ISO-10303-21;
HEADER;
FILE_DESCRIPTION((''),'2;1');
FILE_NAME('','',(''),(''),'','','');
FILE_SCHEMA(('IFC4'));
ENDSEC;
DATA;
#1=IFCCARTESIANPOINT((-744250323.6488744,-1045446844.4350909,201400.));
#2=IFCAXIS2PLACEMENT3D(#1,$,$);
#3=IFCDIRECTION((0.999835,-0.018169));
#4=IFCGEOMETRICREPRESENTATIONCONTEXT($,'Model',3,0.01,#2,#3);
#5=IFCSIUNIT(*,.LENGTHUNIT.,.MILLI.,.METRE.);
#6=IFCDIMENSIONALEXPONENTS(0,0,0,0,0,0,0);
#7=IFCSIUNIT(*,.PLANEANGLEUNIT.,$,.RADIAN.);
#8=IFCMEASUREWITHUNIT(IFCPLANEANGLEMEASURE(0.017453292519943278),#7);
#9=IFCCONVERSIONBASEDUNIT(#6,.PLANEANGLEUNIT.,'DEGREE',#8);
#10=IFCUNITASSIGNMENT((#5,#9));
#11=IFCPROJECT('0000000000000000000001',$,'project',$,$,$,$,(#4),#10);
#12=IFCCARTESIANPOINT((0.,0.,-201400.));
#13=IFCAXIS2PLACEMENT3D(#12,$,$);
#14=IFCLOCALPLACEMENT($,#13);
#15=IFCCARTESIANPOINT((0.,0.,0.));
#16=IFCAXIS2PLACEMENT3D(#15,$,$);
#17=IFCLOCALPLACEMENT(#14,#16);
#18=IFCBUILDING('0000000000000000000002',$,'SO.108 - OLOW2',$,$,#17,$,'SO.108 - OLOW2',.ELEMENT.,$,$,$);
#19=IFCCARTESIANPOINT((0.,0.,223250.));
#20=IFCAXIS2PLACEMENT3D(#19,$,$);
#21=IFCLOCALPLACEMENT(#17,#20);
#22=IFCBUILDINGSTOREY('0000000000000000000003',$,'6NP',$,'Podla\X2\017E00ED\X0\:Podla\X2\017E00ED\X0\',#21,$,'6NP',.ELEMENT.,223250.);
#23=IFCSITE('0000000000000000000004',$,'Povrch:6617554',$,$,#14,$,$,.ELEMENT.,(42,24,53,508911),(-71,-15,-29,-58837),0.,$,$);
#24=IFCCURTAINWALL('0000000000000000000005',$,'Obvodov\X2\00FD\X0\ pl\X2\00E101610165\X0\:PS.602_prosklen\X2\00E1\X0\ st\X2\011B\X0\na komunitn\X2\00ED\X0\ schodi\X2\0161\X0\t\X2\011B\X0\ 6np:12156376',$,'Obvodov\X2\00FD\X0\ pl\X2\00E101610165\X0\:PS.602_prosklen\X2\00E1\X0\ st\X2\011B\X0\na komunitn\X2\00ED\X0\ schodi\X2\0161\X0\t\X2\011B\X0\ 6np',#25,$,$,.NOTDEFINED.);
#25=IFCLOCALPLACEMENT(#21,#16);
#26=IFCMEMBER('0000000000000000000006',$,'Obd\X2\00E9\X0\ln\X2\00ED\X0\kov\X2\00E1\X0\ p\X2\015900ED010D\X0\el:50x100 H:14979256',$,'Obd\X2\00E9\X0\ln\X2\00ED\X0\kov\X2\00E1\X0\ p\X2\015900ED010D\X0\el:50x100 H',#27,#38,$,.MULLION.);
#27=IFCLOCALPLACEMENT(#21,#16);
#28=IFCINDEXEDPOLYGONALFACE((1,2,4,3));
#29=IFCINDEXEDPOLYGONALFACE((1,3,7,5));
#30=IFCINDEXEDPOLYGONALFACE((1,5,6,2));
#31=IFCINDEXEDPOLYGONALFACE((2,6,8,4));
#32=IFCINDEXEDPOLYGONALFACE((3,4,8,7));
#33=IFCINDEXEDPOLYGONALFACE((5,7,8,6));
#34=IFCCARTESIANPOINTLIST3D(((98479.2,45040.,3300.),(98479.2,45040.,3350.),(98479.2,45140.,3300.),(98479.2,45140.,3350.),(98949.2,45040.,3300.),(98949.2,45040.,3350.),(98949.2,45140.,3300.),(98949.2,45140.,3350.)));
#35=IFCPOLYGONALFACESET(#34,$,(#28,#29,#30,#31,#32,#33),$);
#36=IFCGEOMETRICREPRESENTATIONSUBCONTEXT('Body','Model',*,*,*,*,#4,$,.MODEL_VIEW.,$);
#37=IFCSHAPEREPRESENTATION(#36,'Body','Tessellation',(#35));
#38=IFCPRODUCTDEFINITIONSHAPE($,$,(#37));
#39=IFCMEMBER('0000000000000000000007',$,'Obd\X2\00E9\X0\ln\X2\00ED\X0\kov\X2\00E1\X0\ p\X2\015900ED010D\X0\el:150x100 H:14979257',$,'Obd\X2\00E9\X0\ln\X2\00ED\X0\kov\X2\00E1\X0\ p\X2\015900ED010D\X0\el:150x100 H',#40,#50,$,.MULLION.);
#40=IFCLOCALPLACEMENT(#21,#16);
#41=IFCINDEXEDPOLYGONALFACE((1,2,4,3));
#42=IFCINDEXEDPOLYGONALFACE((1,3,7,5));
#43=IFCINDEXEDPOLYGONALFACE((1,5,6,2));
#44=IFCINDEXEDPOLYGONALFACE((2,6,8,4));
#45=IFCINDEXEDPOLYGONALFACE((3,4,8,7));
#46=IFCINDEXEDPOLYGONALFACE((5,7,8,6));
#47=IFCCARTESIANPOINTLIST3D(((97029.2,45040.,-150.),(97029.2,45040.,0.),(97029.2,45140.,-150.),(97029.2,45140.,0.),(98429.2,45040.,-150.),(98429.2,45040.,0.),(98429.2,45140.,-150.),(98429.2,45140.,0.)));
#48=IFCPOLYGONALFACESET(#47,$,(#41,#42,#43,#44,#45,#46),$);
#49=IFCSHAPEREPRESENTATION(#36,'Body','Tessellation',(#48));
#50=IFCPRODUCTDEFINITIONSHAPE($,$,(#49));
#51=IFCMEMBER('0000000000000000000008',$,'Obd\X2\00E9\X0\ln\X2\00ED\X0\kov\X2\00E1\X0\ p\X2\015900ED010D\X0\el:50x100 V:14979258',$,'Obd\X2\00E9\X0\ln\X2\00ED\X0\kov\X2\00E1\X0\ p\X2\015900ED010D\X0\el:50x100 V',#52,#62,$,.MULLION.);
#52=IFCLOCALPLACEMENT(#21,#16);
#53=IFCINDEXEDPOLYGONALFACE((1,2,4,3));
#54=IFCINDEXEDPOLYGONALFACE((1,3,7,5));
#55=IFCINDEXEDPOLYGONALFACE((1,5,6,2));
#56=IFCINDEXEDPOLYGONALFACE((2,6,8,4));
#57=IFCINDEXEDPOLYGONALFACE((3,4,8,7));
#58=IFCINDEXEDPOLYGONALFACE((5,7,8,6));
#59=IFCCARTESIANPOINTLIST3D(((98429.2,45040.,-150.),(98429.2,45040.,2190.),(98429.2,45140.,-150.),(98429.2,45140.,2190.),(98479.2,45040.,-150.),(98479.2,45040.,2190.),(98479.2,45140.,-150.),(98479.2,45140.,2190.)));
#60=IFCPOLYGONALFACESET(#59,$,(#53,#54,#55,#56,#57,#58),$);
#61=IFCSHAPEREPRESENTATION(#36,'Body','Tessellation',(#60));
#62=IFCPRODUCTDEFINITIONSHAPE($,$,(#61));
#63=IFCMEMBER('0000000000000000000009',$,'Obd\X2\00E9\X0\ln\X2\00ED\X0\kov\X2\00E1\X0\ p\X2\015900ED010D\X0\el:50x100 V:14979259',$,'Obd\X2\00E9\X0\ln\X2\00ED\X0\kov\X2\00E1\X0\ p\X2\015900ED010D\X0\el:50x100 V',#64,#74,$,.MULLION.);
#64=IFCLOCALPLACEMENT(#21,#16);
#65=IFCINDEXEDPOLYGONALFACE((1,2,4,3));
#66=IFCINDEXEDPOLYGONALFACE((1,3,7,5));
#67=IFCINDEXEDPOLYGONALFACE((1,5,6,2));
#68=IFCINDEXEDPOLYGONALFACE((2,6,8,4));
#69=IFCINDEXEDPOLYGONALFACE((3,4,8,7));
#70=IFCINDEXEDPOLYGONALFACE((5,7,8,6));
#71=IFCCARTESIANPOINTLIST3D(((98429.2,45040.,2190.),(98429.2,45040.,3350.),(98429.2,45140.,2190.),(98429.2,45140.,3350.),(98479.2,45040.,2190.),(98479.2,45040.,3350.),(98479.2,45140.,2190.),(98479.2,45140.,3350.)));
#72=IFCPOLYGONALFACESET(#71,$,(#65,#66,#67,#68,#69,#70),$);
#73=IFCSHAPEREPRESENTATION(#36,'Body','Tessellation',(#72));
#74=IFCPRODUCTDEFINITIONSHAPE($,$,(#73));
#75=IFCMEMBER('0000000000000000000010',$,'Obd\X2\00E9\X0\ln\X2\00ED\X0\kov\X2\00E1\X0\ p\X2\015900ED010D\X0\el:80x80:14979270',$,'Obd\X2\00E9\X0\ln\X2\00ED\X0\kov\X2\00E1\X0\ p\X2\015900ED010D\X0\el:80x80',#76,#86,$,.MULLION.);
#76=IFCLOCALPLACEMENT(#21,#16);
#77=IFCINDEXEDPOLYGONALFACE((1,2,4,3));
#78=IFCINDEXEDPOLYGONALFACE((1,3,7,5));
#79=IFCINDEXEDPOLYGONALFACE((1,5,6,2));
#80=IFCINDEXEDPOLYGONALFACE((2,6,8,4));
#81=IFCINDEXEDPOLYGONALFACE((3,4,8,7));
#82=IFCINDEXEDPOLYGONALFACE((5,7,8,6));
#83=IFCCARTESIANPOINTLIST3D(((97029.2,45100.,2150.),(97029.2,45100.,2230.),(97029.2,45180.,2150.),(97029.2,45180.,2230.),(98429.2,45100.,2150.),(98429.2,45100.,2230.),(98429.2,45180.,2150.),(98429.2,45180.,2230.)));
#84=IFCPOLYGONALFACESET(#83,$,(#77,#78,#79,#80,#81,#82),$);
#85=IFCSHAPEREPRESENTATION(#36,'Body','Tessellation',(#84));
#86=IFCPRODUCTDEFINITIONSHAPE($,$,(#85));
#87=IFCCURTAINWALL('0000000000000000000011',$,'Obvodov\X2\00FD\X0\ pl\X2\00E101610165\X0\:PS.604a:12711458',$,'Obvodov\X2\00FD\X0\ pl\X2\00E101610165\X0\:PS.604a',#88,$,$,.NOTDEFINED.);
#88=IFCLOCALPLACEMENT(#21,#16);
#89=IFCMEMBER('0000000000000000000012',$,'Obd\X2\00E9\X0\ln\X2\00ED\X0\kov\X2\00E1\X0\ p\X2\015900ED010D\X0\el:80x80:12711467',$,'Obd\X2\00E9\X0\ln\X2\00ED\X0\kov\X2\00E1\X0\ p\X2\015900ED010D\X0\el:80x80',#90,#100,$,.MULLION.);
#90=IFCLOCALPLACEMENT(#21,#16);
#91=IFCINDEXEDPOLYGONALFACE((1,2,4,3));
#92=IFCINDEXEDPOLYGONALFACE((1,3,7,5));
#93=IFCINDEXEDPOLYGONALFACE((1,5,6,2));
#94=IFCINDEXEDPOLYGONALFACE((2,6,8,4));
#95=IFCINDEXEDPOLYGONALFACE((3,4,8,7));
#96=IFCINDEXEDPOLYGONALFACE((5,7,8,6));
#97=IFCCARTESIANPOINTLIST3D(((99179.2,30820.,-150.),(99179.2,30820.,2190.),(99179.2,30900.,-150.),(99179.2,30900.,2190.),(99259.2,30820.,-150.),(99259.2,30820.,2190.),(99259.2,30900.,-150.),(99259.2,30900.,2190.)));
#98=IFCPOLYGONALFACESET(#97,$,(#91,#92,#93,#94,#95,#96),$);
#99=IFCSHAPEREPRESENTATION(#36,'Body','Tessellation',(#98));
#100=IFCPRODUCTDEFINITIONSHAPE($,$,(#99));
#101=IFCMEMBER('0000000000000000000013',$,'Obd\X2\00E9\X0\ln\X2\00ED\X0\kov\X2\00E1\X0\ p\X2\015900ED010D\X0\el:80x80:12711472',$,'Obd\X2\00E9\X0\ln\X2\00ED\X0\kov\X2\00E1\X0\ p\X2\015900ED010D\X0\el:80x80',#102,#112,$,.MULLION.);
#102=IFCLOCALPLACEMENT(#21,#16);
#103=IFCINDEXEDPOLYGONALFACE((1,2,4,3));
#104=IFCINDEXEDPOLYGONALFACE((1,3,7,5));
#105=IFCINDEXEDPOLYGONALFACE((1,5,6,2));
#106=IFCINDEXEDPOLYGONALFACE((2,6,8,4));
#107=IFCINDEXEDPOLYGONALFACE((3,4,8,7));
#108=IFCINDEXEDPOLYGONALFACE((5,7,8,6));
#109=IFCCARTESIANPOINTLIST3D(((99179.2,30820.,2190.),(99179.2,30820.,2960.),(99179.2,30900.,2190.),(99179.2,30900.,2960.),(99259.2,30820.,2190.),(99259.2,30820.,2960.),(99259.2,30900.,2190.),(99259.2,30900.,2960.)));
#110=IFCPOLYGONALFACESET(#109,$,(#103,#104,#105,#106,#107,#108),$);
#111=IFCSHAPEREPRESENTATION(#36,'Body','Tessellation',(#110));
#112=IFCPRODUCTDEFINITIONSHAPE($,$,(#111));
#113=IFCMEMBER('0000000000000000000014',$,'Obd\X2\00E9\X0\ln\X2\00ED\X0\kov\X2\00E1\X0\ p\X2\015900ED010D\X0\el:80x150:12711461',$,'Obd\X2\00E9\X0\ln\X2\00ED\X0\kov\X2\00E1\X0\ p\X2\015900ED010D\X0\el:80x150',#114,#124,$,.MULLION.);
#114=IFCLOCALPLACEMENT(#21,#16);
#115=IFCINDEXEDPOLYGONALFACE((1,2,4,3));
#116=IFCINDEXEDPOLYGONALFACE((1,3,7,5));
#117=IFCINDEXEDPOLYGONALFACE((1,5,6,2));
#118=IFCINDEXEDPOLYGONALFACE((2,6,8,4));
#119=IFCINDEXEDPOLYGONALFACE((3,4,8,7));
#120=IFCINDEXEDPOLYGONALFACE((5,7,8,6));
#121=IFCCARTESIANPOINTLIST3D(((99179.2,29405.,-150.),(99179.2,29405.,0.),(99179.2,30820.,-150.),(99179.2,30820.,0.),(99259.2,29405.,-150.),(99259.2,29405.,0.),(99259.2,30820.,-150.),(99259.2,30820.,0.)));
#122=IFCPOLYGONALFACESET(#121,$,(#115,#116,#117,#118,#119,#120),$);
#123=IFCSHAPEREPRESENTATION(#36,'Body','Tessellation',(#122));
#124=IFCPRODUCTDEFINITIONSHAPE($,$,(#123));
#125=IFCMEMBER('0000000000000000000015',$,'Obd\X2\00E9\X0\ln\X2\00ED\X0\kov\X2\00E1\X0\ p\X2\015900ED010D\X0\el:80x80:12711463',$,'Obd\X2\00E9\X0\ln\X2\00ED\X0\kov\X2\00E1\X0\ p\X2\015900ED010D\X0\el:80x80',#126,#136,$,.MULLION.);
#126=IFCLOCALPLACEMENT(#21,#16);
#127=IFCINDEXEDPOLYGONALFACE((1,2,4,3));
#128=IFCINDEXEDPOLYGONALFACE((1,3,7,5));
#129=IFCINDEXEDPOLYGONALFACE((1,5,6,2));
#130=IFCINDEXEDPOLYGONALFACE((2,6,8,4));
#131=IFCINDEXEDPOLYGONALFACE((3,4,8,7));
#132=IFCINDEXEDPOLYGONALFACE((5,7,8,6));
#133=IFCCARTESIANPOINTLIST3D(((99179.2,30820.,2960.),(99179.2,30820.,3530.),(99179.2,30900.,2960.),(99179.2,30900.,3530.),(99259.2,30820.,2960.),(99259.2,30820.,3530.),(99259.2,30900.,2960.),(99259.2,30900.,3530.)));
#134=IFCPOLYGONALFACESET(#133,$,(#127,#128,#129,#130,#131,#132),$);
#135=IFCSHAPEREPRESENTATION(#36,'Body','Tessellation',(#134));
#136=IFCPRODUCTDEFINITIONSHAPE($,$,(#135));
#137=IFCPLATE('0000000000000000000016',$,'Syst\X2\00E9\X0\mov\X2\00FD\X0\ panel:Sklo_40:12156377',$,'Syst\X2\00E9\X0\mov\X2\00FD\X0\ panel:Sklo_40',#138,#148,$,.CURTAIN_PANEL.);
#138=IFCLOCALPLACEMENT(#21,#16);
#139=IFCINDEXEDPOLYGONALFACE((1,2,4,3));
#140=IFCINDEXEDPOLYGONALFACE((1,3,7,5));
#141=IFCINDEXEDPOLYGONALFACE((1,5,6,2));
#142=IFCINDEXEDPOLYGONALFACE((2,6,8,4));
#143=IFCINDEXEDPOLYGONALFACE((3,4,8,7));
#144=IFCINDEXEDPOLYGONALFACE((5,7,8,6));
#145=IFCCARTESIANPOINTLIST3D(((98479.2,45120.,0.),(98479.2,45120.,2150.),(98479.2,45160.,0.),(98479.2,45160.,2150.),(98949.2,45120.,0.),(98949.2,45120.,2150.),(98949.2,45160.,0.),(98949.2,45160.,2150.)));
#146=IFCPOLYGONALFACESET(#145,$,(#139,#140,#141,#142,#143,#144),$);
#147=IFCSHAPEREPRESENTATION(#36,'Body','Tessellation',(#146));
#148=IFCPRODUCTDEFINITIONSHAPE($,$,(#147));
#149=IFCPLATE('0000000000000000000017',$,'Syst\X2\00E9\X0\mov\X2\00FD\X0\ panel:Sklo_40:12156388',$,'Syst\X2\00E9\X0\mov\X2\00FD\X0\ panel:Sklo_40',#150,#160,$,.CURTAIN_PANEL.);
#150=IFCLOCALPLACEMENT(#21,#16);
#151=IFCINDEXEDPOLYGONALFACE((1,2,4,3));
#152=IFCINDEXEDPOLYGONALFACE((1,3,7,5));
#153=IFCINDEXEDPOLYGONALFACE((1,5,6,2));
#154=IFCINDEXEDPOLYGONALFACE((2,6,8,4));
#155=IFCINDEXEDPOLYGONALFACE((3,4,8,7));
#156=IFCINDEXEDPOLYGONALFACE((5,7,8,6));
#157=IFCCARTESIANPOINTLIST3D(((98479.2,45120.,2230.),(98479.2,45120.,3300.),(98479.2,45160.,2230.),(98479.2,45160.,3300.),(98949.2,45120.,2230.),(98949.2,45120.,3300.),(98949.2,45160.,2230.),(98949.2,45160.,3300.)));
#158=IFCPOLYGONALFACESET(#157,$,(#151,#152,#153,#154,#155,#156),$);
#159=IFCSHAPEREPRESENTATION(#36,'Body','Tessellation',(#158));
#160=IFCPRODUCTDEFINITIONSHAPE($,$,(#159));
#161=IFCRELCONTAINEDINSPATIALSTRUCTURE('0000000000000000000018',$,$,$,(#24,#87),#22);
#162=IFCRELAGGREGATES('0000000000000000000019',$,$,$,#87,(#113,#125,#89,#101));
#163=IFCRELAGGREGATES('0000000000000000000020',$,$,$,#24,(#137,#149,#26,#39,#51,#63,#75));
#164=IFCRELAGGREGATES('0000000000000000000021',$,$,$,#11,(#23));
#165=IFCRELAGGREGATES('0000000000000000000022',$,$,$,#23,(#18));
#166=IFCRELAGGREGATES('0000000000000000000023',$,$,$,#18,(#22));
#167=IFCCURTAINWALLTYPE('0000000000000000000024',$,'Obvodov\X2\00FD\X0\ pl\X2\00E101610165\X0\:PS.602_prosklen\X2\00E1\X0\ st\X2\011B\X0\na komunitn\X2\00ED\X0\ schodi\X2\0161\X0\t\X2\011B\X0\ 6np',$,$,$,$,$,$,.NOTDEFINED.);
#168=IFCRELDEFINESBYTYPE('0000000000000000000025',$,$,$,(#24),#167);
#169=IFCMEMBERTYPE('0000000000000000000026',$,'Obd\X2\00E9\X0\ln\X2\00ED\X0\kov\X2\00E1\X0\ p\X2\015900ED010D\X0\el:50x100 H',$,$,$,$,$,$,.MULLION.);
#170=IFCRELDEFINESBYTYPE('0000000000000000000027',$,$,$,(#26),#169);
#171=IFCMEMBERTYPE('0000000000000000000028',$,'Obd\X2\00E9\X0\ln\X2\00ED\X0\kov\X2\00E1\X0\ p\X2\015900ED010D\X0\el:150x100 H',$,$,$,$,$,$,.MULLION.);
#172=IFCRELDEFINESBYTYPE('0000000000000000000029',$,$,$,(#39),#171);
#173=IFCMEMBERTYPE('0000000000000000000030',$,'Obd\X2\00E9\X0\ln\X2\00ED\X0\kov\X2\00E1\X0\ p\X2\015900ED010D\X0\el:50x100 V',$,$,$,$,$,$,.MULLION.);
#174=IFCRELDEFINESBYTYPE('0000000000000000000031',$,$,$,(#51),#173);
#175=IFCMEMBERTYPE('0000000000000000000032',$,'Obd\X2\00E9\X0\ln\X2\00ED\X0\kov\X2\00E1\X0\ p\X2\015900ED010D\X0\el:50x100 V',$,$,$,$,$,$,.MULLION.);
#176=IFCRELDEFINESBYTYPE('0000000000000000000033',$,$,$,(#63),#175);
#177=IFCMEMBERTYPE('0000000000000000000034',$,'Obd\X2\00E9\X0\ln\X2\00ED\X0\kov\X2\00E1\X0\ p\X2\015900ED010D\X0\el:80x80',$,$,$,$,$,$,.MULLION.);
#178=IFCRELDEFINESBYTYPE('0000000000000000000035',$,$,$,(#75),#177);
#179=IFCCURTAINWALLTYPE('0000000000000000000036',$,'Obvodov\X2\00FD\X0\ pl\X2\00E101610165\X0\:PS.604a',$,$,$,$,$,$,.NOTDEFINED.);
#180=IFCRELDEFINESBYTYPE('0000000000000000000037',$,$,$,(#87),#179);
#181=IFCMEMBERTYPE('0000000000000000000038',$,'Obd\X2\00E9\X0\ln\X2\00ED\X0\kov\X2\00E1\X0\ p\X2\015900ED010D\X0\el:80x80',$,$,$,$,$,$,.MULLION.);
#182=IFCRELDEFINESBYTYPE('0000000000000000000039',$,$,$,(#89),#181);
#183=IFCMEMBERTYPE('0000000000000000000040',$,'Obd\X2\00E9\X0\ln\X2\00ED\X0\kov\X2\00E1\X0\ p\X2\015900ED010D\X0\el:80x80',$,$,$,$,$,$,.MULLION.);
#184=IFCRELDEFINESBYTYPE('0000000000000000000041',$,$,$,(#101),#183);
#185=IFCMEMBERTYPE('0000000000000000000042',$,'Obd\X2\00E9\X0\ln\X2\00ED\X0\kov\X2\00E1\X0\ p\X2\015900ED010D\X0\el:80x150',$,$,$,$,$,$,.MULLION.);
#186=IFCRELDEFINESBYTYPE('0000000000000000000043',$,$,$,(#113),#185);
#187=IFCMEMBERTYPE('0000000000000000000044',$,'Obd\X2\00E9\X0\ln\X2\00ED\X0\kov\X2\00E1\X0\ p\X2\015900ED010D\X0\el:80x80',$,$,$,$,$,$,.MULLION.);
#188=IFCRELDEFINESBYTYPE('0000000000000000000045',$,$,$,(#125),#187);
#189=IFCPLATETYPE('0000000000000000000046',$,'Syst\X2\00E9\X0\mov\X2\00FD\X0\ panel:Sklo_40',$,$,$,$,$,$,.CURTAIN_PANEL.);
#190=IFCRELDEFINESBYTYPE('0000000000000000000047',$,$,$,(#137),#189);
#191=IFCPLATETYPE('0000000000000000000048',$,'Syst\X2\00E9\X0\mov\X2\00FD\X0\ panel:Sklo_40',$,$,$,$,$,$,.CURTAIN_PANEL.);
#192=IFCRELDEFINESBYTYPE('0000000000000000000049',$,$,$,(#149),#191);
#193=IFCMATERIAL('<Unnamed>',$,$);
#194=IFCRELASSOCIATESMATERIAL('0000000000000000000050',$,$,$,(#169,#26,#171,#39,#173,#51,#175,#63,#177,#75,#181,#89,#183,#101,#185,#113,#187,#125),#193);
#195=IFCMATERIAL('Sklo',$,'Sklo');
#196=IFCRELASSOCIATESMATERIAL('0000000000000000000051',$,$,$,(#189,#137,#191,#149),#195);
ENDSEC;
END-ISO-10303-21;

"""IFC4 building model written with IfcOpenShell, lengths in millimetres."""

from ifc_helpers import new_model, entity, si_unit, converted_unit, direction, frame, origin, place, context, subcontext, project, spatial, indexed_curve, outline, extrude, source, transform, mapped, material, type_object, type_shapes, element, aggregate, save


model = new_model("IFC4")

# Units and contexts
model_context = context("Model", 3, precision=0.01, world=frame((-744250323.6488744, -1045446844.4350909, 201400.0)), true_north=direction((0.999835, -0.018169)))
body_context = subcontext(model_context, "Body", "Model", "MODEL_VIEW")
ifc_project = project(units=[si_unit("LENGTHUNIT", "METRE", prefix="MILLI"), converted_unit("PLANEANGLEUNIT", "DEGREE", entity("IfcPlaneAngleMeasure", 0.017453292519943278), si_unit("PLANEANGLEUNIT", "RADIAN"), dimensions=[0, 0, 0, 0, 0, 0, 0])], contexts=[model_context])

# Site, building, storey
site_placement = place(None, frame((0.0, 0.0, -201400.0)))
site = spatial("IfcSite", under=ifc_project, at=site_placement, Name="Povrch:6617554", CompositionType="ELEMENT", RefLatitude=(42, 24, 53, 508911), RefLongitude=(-71, -15, -29, -58837), RefElevation=0.0)
building_placement = place(site_placement, origin())
building = spatial("IfcBuilding", under=site, at=building_placement, Name="SO.108 - OLOW2", LongName="SO.108 - OLOW2", CompositionType="ELEMENT")
storey_placement = place(building_placement, frame((0.0, 0.0, 223250.0)))
storey = spatial("IfcBuildingStorey", under=building, at=storey_placement, Name="6NP", ObjectType="Podlaží:Podlaží", LongName="6NP", CompositionType="ELEMENT", Elevation=223250.0)

# Curtain walls, members
curtain_wall_type_1 = type_object("IfcCurtainWallType", Name="Obvodový plášť:PS.602_prosklená stěna komunitní schodiště 6np", PredefinedType="NOTDEFINED")
curtain_wall_1_placement = place(storey_placement, frame((0.0, 0.0, -223250.0)))
curtain_wall_1 = element("IfcCurtainWall", 1, at=curtain_wall_1_placement, inside=storey, type_object=curtain_wall_type_1, Name="Obvodový plášť:PS.602_prosklená stěna komunitní schodiště 6np:12156376", ObjectType="Obvodový plášť:PS.602_prosklená stěna komunitní schodiště 6np", PredefinedType="NOTDEFINED")
ifc_material_1 = material(Name="<Unnamed>")
member_type_1 = type_object("IfcMemberType", Name="Obdélníková příčel:50x100 H", PredefinedType="MULLION", material=ifc_material_1)
shared_shape_1 = source(origin(), body_context, "Body", "SweptSolid", [
    extrude(outline(indexed_curve([(-25.0, -50.0), (25.0, -50.0), (25.0, 50.0), (-25.0, 50.0), (-25.0, -50.0)], self_intersect=False)), frame((-25.0, -50.0, -470.0), z_axis=(0.0, 0.0, 1.0), x_axis=(-1.0, 0.0, 0.0)), (0.0, 0.0, 1.0), 470.0),
])
type_shapes(member_type_1, [shared_shape_1])
member_1_placement = place(curtain_wall_1_placement, frame((98479.2, 45140.0, 226600.0), z_axis=(-1.0, 0.0, 0.0), x_axis=(0.0, 0.0, 1.0)))
member_1 = element("IfcMember", 2, at=member_1_placement, type_object=member_type_1, material=ifc_material_1, Name="Obdélníková příčel:50x100 H:14979256", ObjectType="Obdélníková příčel:50x100 H", PredefinedType="MULLION", context=body_context, shape_type="MappedRepresentation", body=[
    mapped(shared_shape_1, transform((0.0, 0.0, 0.0), scale=1.0)),
])
member_type_2 = type_object("IfcMemberType", Name="Obdélníková příčel:150x100 H", PredefinedType="MULLION", material=ifc_material_1)
shared_shape_2 = source(origin(), body_context, "Body", "SweptSolid", [
    extrude(outline(indexed_curve([(-75.0, -50.0), (75.0, -50.0), (75.0, 50.0), (-75.0, 50.0), (-75.0, -50.0)], self_intersect=False)), frame((-75.0, -50.0, -1400.0), z_axis=(0.0, 0.0, 1.0), x_axis=(-1.0, 0.0, 0.0)), (0.0, 0.0, 1.0), 1400.0),
])
type_shapes(member_type_2, [shared_shape_2])
member_2_placement = place(curtain_wall_1_placement, frame((98429.2, 45140.0, 223100.0), z_axis=(1.0, 0.0, 0.0), x_axis=(0.0, 0.0, -1.0)))
member_2 = element("IfcMember", 3, at=member_2_placement, type_object=member_type_2, material=ifc_material_1, Name="Obdélníková příčel:150x100 H:14979257", ObjectType="Obdélníková příčel:150x100 H", PredefinedType="MULLION", context=body_context, shape_type="MappedRepresentation", body=[
    mapped(shared_shape_2, transform((0.0, 0.0, 0.0), scale=1.0)),
])
member_type_3 = type_object("IfcMemberType", Name="Obdélníková příčel:50x100 V", PredefinedType="MULLION", material=ifc_material_1)
shared_shape_3 = source(origin(), body_context, "Body", "SweptSolid", [
    extrude(outline(indexed_curve([(-25.0, -50.0), (25.0, -50.0), (25.0, 50.0), (-25.0, 50.0), (-25.0, -50.0)], self_intersect=False)), frame((0.0, -50.0, -2340.0), z_axis=(0.0, 0.0, 1.0), x_axis=(-1.0, 0.0, 0.0)), (0.0, 0.0, 1.0), 2340.0),
])
type_shapes(member_type_3, [shared_shape_3])
member_3_placement = place(curtain_wall_1_placement, frame((98454.2, 45140.0, 223100.0), z_axis=(0.0, 0.0, -1.0), x_axis=(-1.0, 0.0, 0.0)))
member_3 = element("IfcMember", 4, at=member_3_placement, type_object=member_type_3, material=ifc_material_1, Name="Obdélníková příčel:50x100 V:14979258", ObjectType="Obdélníková příčel:50x100 V", PredefinedType="MULLION", context=body_context, shape_type="MappedRepresentation", body=[
    mapped(shared_shape_3, transform((0.0, 0.0, 0.0), scale=1.0)),
])
member_type_4 = type_object("IfcMemberType", Name="Obdélníková příčel:50x100 V", PredefinedType="MULLION", material=ifc_material_1)
shared_shape_4 = source(origin(), body_context, "Body", "SweptSolid", [
    extrude(outline(indexed_curve([(-25.0, -50.0), (25.0, -50.0), (25.0, 50.0), (-25.0, 50.0), (-25.0, -50.0)], self_intersect=False)), frame((0.0, -50.0, -1160.0), z_axis=(0.0, 0.0, 1.0), x_axis=(-1.0, 0.0, 0.0)), (0.0, 0.0, 1.0), 1160.0),
])
type_shapes(member_type_4, [shared_shape_4])
member_4_placement = place(curtain_wall_1_placement, frame((98454.2, 45140.0, 225440.0), z_axis=(0.0, 0.0, -1.0), x_axis=(-1.0, 0.0, 0.0)))
member_4 = element("IfcMember", 5, at=member_4_placement, type_object=member_type_4, material=ifc_material_1, Name="Obdélníková příčel:50x100 V:14979259", ObjectType="Obdélníková příčel:50x100 V", PredefinedType="MULLION", context=body_context, shape_type="MappedRepresentation", body=[
    mapped(shared_shape_4, transform((0.0, 0.0, 0.0), scale=1.0)),
])
member_type_5 = type_object("IfcMemberType", Name="Obdélníková příčel:80x80", PredefinedType="MULLION", material=ifc_material_1)
shared_shape_5 = source(origin(), body_context, "Body", "SweptSolid", [
    extrude(outline(indexed_curve([(-40.0, -40.0), (40.0, -40.0), (40.0, 40.0), (-40.0, 40.0), (-40.0, -40.0)], self_intersect=False)), frame((0.0, 0.0, -1400.0), z_axis=(0.0, 0.0, 1.0), x_axis=(-1.0, 0.0, 0.0)), (0.0, 0.0, 1.0), 1400.0),
])
type_shapes(member_type_5, [shared_shape_5])
member_5_placement = place(curtain_wall_1_placement, frame((97029.2, 45140.0, 225440.0), z_axis=(-1.0, 0.0, 0.0), x_axis=(0.0, 0.0, 1.0)))
member_5 = element("IfcMember", 6, at=member_5_placement, type_object=member_type_5, material=ifc_material_1, Name="Obdélníková příčel:80x80:14979270", ObjectType="Obdélníková příčel:80x80", PredefinedType="MULLION", context=body_context, shape_type="MappedRepresentation", body=[
    mapped(shared_shape_5, transform((0.0, 0.0, 0.0), scale=1.0)),
])
curtain_wall_type_2 = type_object("IfcCurtainWallType", Name="Obvodový plášť:PS.604a", PredefinedType="NOTDEFINED")
curtain_wall_2_placement = place(storey_placement, frame((0.0, 0.0, -223250.0)))
curtain_wall_2 = element("IfcCurtainWall", 7, at=curtain_wall_2_placement, inside=storey, type_object=curtain_wall_type_2, Name="Obvodový plášť:PS.604a:12711458", ObjectType="Obvodový plášť:PS.604a", PredefinedType="NOTDEFINED")
member_type_6 = type_object("IfcMemberType", Name="Obdélníková příčel:80x80", PredefinedType="MULLION", material=ifc_material_1)
shared_shape_6 = source(origin(), body_context, "Body", "SweptSolid", [
    extrude(outline(indexed_curve([(-40.0, -40.0), (40.0, -40.0), (40.0, 40.0), (-40.0, 40.0), (-40.0, -40.0)], self_intersect=False)), frame((-40.0, 0.0, -2340.0), z_axis=(0.0, 0.0, 1.0), x_axis=(-1.0, 0.0, 0.0)), (0.0, 0.0, 1.0), 2340.0),
])
type_shapes(member_type_6, [shared_shape_6])
member_6_placement = place(curtain_wall_2_placement, frame((99219.2, 30900.0, 225440.0), z_axis=(0.0, 0.0, 1.0), x_axis=(0.0, 1.0, 0.0)))
member_6 = element("IfcMember", 8, at=member_6_placement, type_object=member_type_6, material=ifc_material_1, Name="Obdélníková příčel:80x80:12711467", ObjectType="Obdélníková příčel:80x80", PredefinedType="MULLION", context=body_context, shape_type="MappedRepresentation", body=[
    mapped(shared_shape_6, transform((0.0, 0.0, 0.0), scale=1.0)),
])
member_type_7 = type_object("IfcMemberType", Name="Obdélníková příčel:80x80", PredefinedType="MULLION", material=ifc_material_1)
shared_shape_7 = source(origin(), body_context, "Body", "SweptSolid", [
    extrude(outline(indexed_curve([(-40.0, -40.0), (40.0, -40.0), (40.0, 40.0), (-40.0, 40.0), (-40.0, -40.0)], self_intersect=False)), frame((-40.0, 0.0, -770.0), z_axis=(0.0, 0.0, 1.0), x_axis=(-1.0, 0.0, 0.0)), (0.0, 0.0, 1.0), 770.0),
])
type_shapes(member_type_7, [shared_shape_7])
member_7_placement = place(curtain_wall_2_placement, frame((99219.2, 30900.0, 226210.0), z_axis=(0.0, 0.0, 1.0), x_axis=(0.0, 1.0, 0.0)))
member_7 = element("IfcMember", 9, at=member_7_placement, type_object=member_type_7, material=ifc_material_1, Name="Obdélníková příčel:80x80:12711472", ObjectType="Obdélníková příčel:80x80", PredefinedType="MULLION", context=body_context, shape_type="MappedRepresentation", body=[
    mapped(shared_shape_7, transform((0.0, 0.0, 0.0), scale=1.0)),
])
member_type_8 = type_object("IfcMemberType", Name="Obdélníková příčel:80x150", PredefinedType="MULLION", material=ifc_material_1)
shared_shape_8 = source(origin(), body_context, "Body", "SweptSolid", [
    extrude(outline(indexed_curve([(-75.0, -40.0), (75.0, -40.0), (75.0, 40.0), (-75.0, 40.0), (-75.0, -40.0)], self_intersect=False)), frame((-75.0, 0.0, -1415.0), z_axis=(0.0, 0.0, 1.0), x_axis=(-1.0, 0.0, 0.0)), (0.0, 0.0, 1.0), 1415.0),
])
type_shapes(member_type_8, [shared_shape_8])
member_8_placement = place(curtain_wall_2_placement, frame((99219.2, 30820.0, 223100.0), z_axis=(0.0, 1.0, 0.0), x_axis=(0.0, 0.0, -1.0)))
member_8 = element("IfcMember", 10, at=member_8_placement, type_object=member_type_8, material=ifc_material_1, Name="Obdélníková příčel:80x150:12711461", ObjectType="Obdélníková příčel:80x150", PredefinedType="MULLION", context=body_context, shape_type="MappedRepresentation", body=[
    mapped(shared_shape_8, transform((0.0, 0.0, 0.0), scale=1.0)),
])
member_type_9 = type_object("IfcMemberType", Name="Obdélníková příčel:80x80", PredefinedType="MULLION", material=ifc_material_1)
shared_shape_9 = source(origin(), body_context, "Body", "SweptSolid", [
    extrude(outline(indexed_curve([(-40.0, -40.0), (40.0, -40.0), (40.0, 40.0), (-40.0, 40.0), (-40.0, -40.0)], self_intersect=False)), frame((-40.0, 0.0, -570.0), z_axis=(0.0, 0.0, 1.0), x_axis=(-1.0, 0.0, 0.0)), (0.0, 0.0, 1.0), 570.0),
])
type_shapes(member_type_9, [shared_shape_9])
member_9_placement = place(curtain_wall_2_placement, frame((99219.2, 30900.0, 226780.0), z_axis=(0.0, 0.0, 1.0), x_axis=(0.0, 1.0, 0.0)))
member_9 = element("IfcMember", 11, at=member_9_placement, type_object=member_type_9, material=ifc_material_1, Name="Obdélníková příčel:80x80:12711463", ObjectType="Obdélníková příčel:80x80", PredefinedType="MULLION", context=body_context, shape_type="MappedRepresentation", body=[
    mapped(shared_shape_9, transform((0.0, 0.0, 0.0), scale=1.0)),
])
aggregate(curtain_wall_2, [member_8, member_9, member_6, member_7])

# Plates
ifc_material_2 = material(Name="Sklo", Category="Sklo")
plate_type_1 = type_object("IfcPlateType", Name="Systémový panel:Sklo_40", PredefinedType="CURTAIN_PANEL", material=ifc_material_2)
shared_shape_10 = source(origin(), body_context, "Body", "SweptSolid", [
    extrude(outline(indexed_curve([(-20.0, -235.0), (20.0, -235.0), (20.0, 235.0), (-20.0, 235.0), (-20.0, -235.0)], self_intersect=False)), frame((0.0, 0.0, 0.0), z_axis=(0.0, 0.0, 1.0), x_axis=(0.0, 1.0, 0.0)), (0.0, 0.0, 1.0), 2150.0),
])
type_shapes(plate_type_1, [shared_shape_10])
plate_1_placement = place(curtain_wall_1_placement, frame((98714.2, 45140.0, 223250.0), z_axis=(0.0, 0.0, 1.0), x_axis=(-1.0, 0.0, 0.0)))
plate_1 = element("IfcPlate", 12, at=plate_1_placement, type_object=plate_type_1, material=ifc_material_2, Name="Systémový panel:Sklo_40:12156377", ObjectType="Systémový panel:Sklo_40", PredefinedType="CURTAIN_PANEL", context=body_context, shape_type="MappedRepresentation", body=[
    mapped(shared_shape_10, transform((0.0, 0.0, 0.0), scale=1.0)),
])
plate_type_2 = type_object("IfcPlateType", Name="Systémový panel:Sklo_40", PredefinedType="CURTAIN_PANEL", material=ifc_material_2)
shared_shape_11 = source(origin(), body_context, "Body", "SweptSolid", [
    extrude(outline(indexed_curve([(-20.0, -235.0), (20.0, -235.0), (20.0, 235.0), (-20.0, 235.0), (-20.0, -235.0)], self_intersect=False)), frame((0.0, 0.0, 0.0), z_axis=(0.0, 0.0, 1.0), x_axis=(0.0, 1.0, 0.0)), (0.0, 0.0, 1.0), 1070.0),
])
type_shapes(plate_type_2, [shared_shape_11])
plate_2_placement = place(curtain_wall_1_placement, frame((98714.2, 45140.0, 225480.0), z_axis=(0.0, 0.0, 1.0), x_axis=(-1.0, 0.0, 0.0)))
plate_2 = element("IfcPlate", 13, at=plate_2_placement, type_object=plate_type_2, material=ifc_material_2, Name="Systémový panel:Sklo_40:12156388", ObjectType="Systémový panel:Sklo_40", PredefinedType="CURTAIN_PANEL", context=body_context, shape_type="MappedRepresentation", body=[
    mapped(shared_shape_11, transform((0.0, 0.0, 0.0), scale=1.0)),
])

aggregate(curtain_wall_1, [plate_1, plate_2, member_1, member_2, member_3, member_4, member_5])

save(model, "model.ifc")
